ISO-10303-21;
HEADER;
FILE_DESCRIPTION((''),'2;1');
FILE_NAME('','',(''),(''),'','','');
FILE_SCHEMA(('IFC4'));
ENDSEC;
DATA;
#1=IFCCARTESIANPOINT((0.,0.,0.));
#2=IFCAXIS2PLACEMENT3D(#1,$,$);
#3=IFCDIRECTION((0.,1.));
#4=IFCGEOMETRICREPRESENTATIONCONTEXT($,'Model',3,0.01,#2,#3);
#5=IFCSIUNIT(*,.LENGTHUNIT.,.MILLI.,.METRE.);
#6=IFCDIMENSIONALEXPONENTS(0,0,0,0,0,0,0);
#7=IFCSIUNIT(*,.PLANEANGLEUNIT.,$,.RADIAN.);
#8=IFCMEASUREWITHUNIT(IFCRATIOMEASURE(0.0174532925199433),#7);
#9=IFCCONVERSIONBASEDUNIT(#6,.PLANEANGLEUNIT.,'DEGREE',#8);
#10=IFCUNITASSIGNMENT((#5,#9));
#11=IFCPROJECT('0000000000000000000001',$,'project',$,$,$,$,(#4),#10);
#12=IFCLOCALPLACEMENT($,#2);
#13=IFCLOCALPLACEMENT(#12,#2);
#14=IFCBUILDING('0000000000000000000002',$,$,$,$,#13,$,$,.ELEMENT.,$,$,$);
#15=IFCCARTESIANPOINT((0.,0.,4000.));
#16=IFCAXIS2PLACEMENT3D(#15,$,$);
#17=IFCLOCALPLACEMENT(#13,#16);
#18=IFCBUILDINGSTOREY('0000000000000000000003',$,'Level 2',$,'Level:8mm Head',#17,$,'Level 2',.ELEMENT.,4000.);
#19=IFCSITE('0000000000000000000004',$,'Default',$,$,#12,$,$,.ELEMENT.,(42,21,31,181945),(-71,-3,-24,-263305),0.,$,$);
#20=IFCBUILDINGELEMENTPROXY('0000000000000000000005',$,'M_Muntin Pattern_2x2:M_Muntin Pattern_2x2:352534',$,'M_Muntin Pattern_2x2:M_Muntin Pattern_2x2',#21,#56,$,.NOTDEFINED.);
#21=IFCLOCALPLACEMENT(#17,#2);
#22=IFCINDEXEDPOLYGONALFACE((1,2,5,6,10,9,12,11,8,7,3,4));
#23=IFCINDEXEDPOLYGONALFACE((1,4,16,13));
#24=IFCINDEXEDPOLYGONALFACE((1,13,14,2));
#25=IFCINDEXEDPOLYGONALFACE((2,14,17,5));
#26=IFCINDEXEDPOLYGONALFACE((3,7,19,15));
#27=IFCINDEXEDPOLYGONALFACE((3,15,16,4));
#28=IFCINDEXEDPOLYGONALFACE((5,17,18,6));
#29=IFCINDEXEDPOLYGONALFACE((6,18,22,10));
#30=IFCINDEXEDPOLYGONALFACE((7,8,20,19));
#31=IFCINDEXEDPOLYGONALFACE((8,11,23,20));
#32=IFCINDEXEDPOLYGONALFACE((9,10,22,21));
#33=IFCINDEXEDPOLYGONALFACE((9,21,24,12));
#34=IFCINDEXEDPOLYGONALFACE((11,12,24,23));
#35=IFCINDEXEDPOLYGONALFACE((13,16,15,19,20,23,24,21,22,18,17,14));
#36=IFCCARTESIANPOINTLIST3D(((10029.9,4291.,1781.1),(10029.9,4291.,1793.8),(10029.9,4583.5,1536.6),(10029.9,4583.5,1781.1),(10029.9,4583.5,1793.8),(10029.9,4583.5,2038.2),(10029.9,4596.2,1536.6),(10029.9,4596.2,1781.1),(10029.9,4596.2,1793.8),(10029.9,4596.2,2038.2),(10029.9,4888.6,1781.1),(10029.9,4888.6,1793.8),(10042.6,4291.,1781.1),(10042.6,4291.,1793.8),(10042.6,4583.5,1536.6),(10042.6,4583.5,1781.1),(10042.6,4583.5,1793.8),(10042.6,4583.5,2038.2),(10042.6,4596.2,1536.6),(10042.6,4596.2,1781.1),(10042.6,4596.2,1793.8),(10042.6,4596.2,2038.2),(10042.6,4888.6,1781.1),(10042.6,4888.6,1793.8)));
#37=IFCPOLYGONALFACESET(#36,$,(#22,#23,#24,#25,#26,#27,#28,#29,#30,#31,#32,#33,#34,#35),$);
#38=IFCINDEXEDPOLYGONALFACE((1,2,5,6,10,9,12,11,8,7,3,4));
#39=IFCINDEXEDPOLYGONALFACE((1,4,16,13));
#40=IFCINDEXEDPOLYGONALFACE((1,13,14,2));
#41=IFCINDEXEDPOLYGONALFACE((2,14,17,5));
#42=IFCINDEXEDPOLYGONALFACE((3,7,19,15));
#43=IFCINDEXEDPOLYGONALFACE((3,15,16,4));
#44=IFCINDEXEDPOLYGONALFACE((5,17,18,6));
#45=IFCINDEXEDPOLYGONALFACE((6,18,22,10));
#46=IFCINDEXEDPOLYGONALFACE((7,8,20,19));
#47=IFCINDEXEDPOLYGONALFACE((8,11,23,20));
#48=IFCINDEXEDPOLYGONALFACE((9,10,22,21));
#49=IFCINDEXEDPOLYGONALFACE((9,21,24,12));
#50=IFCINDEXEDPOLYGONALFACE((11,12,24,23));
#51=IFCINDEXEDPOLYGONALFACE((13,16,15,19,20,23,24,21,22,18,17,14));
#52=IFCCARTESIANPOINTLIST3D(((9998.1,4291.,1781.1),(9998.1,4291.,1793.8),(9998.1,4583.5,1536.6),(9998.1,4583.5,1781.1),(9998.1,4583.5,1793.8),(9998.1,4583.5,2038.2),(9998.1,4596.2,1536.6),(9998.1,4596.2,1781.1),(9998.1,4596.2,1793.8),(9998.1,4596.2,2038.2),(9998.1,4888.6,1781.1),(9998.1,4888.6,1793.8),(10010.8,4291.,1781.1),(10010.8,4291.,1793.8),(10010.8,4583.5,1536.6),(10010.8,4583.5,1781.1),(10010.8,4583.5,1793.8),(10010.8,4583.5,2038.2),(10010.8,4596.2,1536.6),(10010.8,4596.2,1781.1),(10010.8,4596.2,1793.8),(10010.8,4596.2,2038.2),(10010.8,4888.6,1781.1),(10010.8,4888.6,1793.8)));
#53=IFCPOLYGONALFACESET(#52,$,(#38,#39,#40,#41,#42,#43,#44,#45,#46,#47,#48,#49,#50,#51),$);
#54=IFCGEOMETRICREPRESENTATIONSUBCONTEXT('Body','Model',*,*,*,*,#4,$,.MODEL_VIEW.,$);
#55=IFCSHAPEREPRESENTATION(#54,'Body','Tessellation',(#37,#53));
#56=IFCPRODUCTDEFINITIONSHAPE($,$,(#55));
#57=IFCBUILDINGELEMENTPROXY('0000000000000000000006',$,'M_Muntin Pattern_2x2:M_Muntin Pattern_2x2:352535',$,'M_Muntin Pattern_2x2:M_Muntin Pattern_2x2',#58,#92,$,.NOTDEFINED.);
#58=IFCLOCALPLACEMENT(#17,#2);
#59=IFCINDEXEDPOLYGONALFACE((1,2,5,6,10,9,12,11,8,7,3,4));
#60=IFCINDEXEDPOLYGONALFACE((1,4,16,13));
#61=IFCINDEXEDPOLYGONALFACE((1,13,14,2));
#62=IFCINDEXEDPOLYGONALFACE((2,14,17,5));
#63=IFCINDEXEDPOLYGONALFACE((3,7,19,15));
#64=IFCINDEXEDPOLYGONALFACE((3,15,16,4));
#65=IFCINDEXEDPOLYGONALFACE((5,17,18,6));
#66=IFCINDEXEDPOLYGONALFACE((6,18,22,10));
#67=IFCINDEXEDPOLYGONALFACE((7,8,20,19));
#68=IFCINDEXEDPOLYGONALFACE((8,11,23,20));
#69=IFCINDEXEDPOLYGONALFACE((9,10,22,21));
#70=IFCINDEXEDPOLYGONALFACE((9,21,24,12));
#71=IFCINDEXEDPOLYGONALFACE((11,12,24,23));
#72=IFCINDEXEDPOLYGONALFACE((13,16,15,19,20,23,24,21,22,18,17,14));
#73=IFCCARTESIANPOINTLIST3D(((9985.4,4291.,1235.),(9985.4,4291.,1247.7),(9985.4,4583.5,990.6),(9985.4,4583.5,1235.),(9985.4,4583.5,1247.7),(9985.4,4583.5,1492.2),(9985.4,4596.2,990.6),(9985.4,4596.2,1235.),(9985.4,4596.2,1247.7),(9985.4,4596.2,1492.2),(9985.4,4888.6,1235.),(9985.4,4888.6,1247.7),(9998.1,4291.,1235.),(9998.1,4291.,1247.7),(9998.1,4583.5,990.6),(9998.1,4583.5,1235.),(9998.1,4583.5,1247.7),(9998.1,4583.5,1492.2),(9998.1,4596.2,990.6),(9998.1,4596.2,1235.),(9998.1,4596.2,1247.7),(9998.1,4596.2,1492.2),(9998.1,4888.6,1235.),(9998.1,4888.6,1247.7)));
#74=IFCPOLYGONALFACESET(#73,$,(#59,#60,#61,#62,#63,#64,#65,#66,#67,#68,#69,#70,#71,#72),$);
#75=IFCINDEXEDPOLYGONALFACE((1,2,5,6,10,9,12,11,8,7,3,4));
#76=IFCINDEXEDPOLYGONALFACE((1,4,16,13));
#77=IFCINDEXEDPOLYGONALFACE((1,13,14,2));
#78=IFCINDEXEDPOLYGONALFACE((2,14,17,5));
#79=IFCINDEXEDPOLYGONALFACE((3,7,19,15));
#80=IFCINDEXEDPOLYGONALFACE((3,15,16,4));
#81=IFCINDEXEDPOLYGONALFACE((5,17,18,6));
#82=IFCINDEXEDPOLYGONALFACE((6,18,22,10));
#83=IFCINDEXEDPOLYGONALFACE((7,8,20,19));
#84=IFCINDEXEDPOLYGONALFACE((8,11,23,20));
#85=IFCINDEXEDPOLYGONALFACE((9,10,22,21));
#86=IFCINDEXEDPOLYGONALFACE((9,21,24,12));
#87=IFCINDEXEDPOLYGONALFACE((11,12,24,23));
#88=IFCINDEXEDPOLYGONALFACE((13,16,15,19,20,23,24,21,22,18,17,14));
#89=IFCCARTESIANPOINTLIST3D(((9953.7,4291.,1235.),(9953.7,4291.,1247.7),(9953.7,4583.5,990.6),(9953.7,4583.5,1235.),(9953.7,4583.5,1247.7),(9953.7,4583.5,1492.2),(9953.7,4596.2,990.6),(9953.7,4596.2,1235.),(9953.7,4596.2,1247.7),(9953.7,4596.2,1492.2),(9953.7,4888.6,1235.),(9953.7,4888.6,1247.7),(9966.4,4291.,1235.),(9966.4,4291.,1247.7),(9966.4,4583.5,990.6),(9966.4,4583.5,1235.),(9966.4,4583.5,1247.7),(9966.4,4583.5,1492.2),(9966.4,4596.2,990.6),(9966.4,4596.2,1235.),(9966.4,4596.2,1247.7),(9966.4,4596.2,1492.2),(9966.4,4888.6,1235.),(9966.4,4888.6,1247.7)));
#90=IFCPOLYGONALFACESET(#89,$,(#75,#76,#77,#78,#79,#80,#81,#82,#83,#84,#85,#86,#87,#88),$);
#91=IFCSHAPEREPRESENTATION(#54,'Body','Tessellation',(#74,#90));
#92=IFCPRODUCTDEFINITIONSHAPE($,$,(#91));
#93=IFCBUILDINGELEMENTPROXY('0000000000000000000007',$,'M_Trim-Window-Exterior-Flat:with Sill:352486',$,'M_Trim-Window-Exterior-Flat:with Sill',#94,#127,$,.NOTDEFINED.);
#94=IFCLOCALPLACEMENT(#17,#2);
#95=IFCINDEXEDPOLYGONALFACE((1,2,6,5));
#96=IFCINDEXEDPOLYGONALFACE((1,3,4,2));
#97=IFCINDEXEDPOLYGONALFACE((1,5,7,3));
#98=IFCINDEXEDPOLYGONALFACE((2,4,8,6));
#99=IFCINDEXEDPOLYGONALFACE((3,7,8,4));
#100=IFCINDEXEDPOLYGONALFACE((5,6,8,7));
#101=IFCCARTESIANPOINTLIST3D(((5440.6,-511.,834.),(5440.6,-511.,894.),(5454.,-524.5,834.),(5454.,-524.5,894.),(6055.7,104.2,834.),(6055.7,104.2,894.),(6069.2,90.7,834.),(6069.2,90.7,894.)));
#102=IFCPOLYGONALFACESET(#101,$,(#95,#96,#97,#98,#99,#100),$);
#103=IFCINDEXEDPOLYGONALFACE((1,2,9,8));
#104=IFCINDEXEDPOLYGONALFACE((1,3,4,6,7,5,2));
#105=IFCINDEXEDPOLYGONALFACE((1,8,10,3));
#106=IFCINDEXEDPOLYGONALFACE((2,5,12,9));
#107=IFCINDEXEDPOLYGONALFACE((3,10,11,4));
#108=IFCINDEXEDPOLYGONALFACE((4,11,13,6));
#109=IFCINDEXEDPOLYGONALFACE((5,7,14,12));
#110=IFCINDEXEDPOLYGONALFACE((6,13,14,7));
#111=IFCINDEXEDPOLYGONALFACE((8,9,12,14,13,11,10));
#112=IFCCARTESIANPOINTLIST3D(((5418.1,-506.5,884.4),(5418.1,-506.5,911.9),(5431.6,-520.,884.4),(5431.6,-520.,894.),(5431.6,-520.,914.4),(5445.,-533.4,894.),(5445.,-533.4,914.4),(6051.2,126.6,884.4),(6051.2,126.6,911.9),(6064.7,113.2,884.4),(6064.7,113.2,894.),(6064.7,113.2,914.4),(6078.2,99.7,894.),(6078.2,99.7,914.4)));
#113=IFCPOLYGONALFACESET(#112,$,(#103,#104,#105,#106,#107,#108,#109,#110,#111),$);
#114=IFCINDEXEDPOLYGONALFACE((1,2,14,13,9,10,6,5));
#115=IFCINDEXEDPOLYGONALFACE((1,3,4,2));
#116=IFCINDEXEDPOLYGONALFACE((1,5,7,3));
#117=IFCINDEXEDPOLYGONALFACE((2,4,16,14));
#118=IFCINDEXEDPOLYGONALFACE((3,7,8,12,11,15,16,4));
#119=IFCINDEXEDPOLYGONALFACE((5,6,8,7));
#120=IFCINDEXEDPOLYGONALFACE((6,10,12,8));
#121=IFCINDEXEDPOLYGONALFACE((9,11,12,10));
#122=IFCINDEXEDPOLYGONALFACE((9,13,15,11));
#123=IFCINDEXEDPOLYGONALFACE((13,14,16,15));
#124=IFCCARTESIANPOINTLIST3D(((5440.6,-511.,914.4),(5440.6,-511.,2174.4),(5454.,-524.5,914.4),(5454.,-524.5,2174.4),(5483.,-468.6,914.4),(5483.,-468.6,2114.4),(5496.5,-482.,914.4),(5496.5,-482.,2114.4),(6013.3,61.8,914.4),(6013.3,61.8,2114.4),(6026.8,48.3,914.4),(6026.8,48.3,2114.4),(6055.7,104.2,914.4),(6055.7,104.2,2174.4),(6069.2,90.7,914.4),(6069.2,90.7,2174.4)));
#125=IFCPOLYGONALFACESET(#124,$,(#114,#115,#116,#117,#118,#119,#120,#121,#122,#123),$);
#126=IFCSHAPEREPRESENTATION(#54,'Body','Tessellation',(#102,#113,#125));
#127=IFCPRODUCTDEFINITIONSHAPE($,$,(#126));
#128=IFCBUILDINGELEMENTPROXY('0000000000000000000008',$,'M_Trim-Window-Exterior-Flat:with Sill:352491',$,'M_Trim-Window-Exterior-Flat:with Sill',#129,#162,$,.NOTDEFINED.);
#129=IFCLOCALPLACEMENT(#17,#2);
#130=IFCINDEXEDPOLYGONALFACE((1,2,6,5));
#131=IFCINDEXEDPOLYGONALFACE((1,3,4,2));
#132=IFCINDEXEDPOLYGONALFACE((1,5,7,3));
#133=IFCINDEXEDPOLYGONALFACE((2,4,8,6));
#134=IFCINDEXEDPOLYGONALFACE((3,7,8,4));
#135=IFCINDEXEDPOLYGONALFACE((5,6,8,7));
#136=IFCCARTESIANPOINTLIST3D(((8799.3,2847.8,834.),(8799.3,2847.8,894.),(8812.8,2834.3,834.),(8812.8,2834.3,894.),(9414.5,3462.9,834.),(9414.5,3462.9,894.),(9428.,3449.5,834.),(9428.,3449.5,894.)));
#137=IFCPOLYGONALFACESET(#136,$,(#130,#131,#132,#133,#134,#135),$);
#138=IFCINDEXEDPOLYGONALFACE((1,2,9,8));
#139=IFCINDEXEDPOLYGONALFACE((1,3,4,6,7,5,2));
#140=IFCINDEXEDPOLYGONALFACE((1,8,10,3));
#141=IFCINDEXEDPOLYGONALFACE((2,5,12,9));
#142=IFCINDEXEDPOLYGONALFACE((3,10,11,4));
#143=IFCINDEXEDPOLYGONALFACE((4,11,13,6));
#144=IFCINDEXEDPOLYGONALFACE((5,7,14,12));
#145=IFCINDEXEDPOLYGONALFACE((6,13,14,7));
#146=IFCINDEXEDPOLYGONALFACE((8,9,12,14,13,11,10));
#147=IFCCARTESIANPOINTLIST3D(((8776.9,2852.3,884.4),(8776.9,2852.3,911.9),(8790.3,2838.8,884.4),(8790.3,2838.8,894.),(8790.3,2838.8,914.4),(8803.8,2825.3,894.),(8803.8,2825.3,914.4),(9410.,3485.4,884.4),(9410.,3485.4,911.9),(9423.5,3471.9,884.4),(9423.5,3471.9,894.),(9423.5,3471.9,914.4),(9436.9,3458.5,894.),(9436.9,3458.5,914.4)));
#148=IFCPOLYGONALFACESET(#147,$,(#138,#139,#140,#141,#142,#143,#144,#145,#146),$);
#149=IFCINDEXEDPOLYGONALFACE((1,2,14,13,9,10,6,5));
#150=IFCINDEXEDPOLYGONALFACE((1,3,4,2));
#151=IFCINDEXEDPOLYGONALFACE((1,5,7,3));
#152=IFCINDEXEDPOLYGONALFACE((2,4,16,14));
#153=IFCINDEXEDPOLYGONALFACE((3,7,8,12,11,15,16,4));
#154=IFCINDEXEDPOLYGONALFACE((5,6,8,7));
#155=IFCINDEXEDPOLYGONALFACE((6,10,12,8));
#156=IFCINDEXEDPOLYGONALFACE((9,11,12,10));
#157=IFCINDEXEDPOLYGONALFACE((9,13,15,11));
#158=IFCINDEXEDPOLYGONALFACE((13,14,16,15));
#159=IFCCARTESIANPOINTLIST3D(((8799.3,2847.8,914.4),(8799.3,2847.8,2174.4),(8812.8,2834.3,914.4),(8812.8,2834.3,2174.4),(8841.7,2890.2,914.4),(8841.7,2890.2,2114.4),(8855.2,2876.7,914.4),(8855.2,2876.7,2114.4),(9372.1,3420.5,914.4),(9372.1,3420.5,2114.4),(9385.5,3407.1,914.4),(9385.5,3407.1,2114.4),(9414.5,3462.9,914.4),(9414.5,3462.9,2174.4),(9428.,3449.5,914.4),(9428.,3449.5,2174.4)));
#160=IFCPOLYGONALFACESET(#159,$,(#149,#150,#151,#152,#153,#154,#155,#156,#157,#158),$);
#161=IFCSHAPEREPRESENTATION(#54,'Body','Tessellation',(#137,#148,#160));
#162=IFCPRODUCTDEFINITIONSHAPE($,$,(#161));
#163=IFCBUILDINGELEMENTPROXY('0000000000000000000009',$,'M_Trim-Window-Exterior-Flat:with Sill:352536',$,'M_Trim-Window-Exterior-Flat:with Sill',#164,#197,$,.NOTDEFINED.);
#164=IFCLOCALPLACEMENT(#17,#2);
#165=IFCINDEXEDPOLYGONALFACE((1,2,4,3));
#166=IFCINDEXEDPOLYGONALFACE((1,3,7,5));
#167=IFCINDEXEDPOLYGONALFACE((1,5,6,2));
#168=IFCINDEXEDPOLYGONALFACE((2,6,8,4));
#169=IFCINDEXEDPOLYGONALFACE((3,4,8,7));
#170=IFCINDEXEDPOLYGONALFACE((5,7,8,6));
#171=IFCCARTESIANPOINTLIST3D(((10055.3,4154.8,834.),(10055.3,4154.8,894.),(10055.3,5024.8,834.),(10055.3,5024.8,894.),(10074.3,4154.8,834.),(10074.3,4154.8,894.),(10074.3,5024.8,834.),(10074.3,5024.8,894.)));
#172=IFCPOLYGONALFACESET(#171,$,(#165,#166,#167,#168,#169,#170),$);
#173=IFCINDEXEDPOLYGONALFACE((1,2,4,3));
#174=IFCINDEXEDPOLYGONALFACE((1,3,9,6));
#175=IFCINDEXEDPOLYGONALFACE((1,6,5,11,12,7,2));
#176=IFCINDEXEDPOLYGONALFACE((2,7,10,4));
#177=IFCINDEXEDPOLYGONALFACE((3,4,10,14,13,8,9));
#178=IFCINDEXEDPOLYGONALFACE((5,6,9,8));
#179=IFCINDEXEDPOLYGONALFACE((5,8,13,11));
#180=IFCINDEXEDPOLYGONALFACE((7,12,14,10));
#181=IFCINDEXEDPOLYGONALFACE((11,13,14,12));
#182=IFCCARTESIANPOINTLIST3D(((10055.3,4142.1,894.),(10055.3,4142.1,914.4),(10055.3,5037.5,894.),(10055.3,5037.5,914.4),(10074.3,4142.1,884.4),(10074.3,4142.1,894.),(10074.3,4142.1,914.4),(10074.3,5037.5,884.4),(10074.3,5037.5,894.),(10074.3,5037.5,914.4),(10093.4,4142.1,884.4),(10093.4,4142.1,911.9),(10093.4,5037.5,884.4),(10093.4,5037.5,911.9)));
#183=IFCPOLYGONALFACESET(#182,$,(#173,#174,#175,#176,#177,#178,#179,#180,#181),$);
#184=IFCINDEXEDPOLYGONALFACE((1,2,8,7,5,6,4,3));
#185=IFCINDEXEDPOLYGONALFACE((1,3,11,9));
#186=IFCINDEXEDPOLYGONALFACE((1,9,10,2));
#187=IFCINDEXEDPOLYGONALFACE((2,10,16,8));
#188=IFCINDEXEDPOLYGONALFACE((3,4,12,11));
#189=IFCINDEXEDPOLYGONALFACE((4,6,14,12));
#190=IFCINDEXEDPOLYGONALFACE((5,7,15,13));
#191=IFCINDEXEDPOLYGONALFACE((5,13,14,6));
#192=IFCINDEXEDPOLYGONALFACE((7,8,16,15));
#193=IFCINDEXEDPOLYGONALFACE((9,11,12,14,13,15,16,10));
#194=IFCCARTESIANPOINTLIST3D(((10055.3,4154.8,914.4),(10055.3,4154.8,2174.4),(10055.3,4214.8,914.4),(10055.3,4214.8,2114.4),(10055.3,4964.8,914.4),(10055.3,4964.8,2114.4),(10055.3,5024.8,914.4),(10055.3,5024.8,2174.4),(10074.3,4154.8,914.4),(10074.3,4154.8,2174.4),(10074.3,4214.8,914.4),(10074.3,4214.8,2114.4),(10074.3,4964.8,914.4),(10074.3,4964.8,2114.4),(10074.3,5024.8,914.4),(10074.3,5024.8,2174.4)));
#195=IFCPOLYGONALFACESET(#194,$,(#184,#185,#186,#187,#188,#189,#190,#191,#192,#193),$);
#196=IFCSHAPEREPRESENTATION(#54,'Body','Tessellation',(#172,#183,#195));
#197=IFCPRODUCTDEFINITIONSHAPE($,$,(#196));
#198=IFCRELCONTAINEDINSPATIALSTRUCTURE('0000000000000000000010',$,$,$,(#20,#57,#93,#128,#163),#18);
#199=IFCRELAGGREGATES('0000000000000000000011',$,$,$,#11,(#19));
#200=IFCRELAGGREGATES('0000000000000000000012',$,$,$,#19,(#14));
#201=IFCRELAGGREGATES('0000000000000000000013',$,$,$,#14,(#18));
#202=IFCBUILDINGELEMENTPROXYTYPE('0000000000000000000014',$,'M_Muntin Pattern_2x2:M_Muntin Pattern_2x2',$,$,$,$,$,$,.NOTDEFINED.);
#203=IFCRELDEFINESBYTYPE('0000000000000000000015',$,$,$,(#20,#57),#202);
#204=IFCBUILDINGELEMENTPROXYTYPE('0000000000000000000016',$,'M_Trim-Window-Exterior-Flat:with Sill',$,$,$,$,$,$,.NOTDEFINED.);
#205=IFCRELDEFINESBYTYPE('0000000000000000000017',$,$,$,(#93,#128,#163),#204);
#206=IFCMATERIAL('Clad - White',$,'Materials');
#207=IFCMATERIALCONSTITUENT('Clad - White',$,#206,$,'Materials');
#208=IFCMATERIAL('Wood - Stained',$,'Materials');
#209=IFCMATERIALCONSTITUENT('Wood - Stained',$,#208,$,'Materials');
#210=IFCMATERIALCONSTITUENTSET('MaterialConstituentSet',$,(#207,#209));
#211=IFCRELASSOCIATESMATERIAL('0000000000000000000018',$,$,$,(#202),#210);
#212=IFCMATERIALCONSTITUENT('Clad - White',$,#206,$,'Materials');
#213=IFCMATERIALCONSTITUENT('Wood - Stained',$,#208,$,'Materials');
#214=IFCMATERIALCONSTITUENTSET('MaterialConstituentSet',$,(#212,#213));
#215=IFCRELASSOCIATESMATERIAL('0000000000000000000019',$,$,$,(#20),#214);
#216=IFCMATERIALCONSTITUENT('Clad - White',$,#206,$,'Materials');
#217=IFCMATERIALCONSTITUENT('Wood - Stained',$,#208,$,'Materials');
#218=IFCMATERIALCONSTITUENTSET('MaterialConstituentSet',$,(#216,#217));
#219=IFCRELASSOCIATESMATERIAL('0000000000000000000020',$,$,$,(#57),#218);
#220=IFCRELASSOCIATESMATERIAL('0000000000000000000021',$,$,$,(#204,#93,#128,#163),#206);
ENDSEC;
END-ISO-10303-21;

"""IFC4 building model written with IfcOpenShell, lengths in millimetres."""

from ifc_helpers import new_model, entity, si_unit, converted_unit, direction, frame, frame_2d, origin, place, context, subcontext, project, spatial, polyline, rectangle, outline, extrude, source, transform, mapped, material, constituent, constituent_set, type_object, type_shapes, element, save


model = new_model("IFC4")

# Units and contexts
model_context = context("Model", 3, precision=0.01, world=origin(), true_north=direction((0.0, 1.0)))
body_context = subcontext(model_context, "Body", "Model", "MODEL_VIEW")
ifc_project = project(units=[si_unit("LENGTHUNIT", "METRE", prefix="MILLI"), converted_unit("PLANEANGLEUNIT", "DEGREE", entity("IfcRatioMeasure", 0.0174532925199433), si_unit("PLANEANGLEUNIT", "RADIAN"), dimensions=[0, 0, 0, 0, 0, 0, 0])], contexts=[model_context])

# Site, building, storey
site_placement = place(None, origin())
site = spatial("IfcSite", under=ifc_project, at=site_placement, Name="Default", CompositionType="ELEMENT", RefLatitude=(42, 21, 31, 181945), RefLongitude=(-71, -3, -24, -263305), RefElevation=0.0)
building_placement = place(site_placement, origin())
building = spatial("IfcBuilding", under=site, at=building_placement, CompositionType="ELEMENT")
storey_placement = place(building_placement, frame((0.0, 0.0, 4000.0)))
storey = spatial("IfcBuildingStorey", under=building, at=storey_placement, Name="Level 2", ObjectType="Level:8mm Head", LongName="Level 2", CompositionType="ELEMENT", Elevation=4000.0)

# Shared definitions
ifc_material_1 = material(Name="Wood - Stained", Category="Materials")

# Building element proxies
ifc_material_2 = material(Name="Clad - White", Category="Materials")
ifc_constituent_1 = constituent(ifc_material_2, Name="Clad - White", Category="Materials")
ifc_constituent_2 = constituent(ifc_material_1, Name="Wood - Stained", Category="Materials")
ifc_constituent_set_1 = constituent_set(constituents=[ifc_constituent_1, ifc_constituent_2], Name="MaterialConstituentSet")
building_element_proxy_type_1 = type_object("IfcBuildingElementProxyType", Name="M_Muntin Pattern_2x2:M_Muntin Pattern_2x2", PredefinedType="NOTDEFINED", material=ifc_constituent_set_1)
shared_shape_1 = source(origin(), body_context, "Body", "SweptSolid", [
    extrude(outline(polyline([(6.4, -6.4), (250.8, -6.4), (250.8, 6.3), (6.4, 6.3), (6.4, 298.8), (-6.3, 298.8), (-6.3, 6.3), (-250.8, 6.3), (-250.8, -6.4), (-6.3, -6.4), (-6.3, -298.8), (6.4, -298.8), (6.4, -6.4)])), frame((0.0, 9.5, 250.8), z_axis=(0.0, 1.0, 0.0), x_axis=(0.0, 0.0, 1.0)), (0.0, 0.0, 1.0), 12.7),
    extrude(outline(polyline([(6.4, -6.4), (250.8, -6.4), (250.8, 6.3), (6.4, 6.3), (6.4, 298.8), (-6.3, 298.8), (-6.3, 6.3), (-250.8, 6.3), (-250.8, -6.4), (-6.3, -6.4), (-6.3, -298.8), (6.4, -298.8), (6.4, -6.4)])), frame((0.0, -22.2, 250.8), z_axis=(0.0, 1.0, 0.0), x_axis=(0.0, 0.0, 1.0)), (0.0, 0.0, 1.0), 12.7),
])
type_shapes(building_element_proxy_type_1, [shared_shape_1])
ifc_constituent_3 = constituent(ifc_material_2, Name="Clad - White", Category="Materials")
ifc_constituent_4 = constituent(ifc_material_1, Name="Wood - Stained", Category="Materials")
ifc_constituent_set_2 = constituent_set(constituents=[ifc_constituent_3, ifc_constituent_4], Name="MaterialConstituentSet")
proxy_1_placement = place(storey_placement, frame((10020.3, 4589.8, 1536.6), z_axis=(0.0, 0.0, 1.0), x_axis=(0.0, -1.0, 0.0)))
element("IfcBuildingElementProxy", 1, at=proxy_1_placement, inside=storey, type_object=building_element_proxy_type_1, material=ifc_constituent_set_2, Name="M_Muntin Pattern_2x2:M_Muntin Pattern_2x2:352534", ObjectType="M_Muntin Pattern_2x2:M_Muntin Pattern_2x2", PredefinedType="NOTDEFINED", context=body_context, shape_type="MappedRepresentation", body=[
    mapped(shared_shape_1, transform((0.0, 0.0, 0.0), scale=1.0)),
])
ifc_constituent_5 = constituent(ifc_material_2, Name="Clad - White", Category="Materials")
ifc_constituent_6 = constituent(ifc_material_1, Name="Wood - Stained", Category="Materials")
ifc_constituent_set_3 = constituent_set(constituents=[ifc_constituent_5, ifc_constituent_6], Name="MaterialConstituentSet")
proxy_2_placement = place(storey_placement, frame((9975.9, 4589.8, 990.6), z_axis=(0.0, 0.0, 1.0), x_axis=(0.0, -1.0, 0.0)))
element("IfcBuildingElementProxy", 2, at=proxy_2_placement, inside=storey, type_object=building_element_proxy_type_1, material=ifc_constituent_set_3, Name="M_Muntin Pattern_2x2:M_Muntin Pattern_2x2:352535", ObjectType="M_Muntin Pattern_2x2:M_Muntin Pattern_2x2", PredefinedType="NOTDEFINED", context=body_context, shape_type="MappedRepresentation", body=[
    mapped(shared_shape_1, transform((0.0, 0.0, 0.0), scale=1.0)),
])
building_element_proxy_type_2 = type_object("IfcBuildingElementProxyType", Name="M_Trim-Window-Exterior-Flat:with Sill", PredefinedType="NOTDEFINED", material=ifc_material_2)
shared_shape_2 = source(origin(), body_context, "Body", "SweptSolid", [
    extrude(rectangle(XDim=870.0, YDim=60.0, at=frame_2d((0.0, 0.0), x_axis=(1.0, 0.0))), frame((0.0, -1250.4, 0.0), z_axis=(0.0, 0.0, 1.0), x_axis=(-1.0, 0.0, 0.0)), (0.0, 0.0, 1.0), 19.1),
    extrude(outline(polyline([(-19.0, -15.2), (0.0, -15.2), (0.0, -5.7), (19.0, -5.7), (19.0, 14.8), (0.0, 14.8), (-19.0, 12.3), (-19.0, -15.2)])), frame((-447.7, -1214.8, 19.0), z_axis=(1.0, 0.0, 0.0), x_axis=(0.0, 0.0, -1.0)), (0.0, 0.0, 1.0), 895.4),
    extrude(outline(polyline([(-645.0, -435.0), (615.0, -435.0), (615.0, -375.0), (-585.0, -375.0), (-585.0, 375.0), (615.0, 375.0), (615.0, 435.0), (-645.0, 435.0), (-645.0, -435.0)])), frame((0.0, -585.0, 0.0), z_axis=(0.0, 0.0, 1.0), x_axis=(0.0, -1.0, 0.0)), (0.0, 0.0, 1.0), 19.1),
])
type_shapes(building_element_proxy_type_2, [shared_shape_2])
for number, where, z_axis, x_axis, name in (
    (3, (5761.6, -216.9, 2114.4), (-0.707107, 0.707107, 0.0), (-0.707107, -0.707107, 0.0), "M_Trim-Window-Exterior-Flat:with Sill:352486"),
    (4, (9120.4, 3141.9, 2114.4), (-0.707107, 0.707107, 0.0), (-0.707107, -0.707107, 0.0), "M_Trim-Window-Exterior-Flat:with Sill:352491"),
    (5, (10055.3, 4589.8, 2114.4), (1.0, 0.0, 0.0), (0.0, 1.0, 0.0), "M_Trim-Window-Exterior-Flat:with Sill:352536"),
):
    element("IfcBuildingElementProxy", number, at=place(storey_placement, frame(where, z_axis=z_axis, x_axis=x_axis)), inside=storey, type_object=building_element_proxy_type_2, material=ifc_material_2, Name=name, ObjectType="M_Trim-Window-Exterior-Flat:with Sill", PredefinedType="NOTDEFINED", context=body_context, shape_type="MappedRepresentation", body=[
        mapped(shared_shape_2, transform((0.0, 0.0, 0.0), scale=1.0)),
    ])

save(model, "model.ifc")
